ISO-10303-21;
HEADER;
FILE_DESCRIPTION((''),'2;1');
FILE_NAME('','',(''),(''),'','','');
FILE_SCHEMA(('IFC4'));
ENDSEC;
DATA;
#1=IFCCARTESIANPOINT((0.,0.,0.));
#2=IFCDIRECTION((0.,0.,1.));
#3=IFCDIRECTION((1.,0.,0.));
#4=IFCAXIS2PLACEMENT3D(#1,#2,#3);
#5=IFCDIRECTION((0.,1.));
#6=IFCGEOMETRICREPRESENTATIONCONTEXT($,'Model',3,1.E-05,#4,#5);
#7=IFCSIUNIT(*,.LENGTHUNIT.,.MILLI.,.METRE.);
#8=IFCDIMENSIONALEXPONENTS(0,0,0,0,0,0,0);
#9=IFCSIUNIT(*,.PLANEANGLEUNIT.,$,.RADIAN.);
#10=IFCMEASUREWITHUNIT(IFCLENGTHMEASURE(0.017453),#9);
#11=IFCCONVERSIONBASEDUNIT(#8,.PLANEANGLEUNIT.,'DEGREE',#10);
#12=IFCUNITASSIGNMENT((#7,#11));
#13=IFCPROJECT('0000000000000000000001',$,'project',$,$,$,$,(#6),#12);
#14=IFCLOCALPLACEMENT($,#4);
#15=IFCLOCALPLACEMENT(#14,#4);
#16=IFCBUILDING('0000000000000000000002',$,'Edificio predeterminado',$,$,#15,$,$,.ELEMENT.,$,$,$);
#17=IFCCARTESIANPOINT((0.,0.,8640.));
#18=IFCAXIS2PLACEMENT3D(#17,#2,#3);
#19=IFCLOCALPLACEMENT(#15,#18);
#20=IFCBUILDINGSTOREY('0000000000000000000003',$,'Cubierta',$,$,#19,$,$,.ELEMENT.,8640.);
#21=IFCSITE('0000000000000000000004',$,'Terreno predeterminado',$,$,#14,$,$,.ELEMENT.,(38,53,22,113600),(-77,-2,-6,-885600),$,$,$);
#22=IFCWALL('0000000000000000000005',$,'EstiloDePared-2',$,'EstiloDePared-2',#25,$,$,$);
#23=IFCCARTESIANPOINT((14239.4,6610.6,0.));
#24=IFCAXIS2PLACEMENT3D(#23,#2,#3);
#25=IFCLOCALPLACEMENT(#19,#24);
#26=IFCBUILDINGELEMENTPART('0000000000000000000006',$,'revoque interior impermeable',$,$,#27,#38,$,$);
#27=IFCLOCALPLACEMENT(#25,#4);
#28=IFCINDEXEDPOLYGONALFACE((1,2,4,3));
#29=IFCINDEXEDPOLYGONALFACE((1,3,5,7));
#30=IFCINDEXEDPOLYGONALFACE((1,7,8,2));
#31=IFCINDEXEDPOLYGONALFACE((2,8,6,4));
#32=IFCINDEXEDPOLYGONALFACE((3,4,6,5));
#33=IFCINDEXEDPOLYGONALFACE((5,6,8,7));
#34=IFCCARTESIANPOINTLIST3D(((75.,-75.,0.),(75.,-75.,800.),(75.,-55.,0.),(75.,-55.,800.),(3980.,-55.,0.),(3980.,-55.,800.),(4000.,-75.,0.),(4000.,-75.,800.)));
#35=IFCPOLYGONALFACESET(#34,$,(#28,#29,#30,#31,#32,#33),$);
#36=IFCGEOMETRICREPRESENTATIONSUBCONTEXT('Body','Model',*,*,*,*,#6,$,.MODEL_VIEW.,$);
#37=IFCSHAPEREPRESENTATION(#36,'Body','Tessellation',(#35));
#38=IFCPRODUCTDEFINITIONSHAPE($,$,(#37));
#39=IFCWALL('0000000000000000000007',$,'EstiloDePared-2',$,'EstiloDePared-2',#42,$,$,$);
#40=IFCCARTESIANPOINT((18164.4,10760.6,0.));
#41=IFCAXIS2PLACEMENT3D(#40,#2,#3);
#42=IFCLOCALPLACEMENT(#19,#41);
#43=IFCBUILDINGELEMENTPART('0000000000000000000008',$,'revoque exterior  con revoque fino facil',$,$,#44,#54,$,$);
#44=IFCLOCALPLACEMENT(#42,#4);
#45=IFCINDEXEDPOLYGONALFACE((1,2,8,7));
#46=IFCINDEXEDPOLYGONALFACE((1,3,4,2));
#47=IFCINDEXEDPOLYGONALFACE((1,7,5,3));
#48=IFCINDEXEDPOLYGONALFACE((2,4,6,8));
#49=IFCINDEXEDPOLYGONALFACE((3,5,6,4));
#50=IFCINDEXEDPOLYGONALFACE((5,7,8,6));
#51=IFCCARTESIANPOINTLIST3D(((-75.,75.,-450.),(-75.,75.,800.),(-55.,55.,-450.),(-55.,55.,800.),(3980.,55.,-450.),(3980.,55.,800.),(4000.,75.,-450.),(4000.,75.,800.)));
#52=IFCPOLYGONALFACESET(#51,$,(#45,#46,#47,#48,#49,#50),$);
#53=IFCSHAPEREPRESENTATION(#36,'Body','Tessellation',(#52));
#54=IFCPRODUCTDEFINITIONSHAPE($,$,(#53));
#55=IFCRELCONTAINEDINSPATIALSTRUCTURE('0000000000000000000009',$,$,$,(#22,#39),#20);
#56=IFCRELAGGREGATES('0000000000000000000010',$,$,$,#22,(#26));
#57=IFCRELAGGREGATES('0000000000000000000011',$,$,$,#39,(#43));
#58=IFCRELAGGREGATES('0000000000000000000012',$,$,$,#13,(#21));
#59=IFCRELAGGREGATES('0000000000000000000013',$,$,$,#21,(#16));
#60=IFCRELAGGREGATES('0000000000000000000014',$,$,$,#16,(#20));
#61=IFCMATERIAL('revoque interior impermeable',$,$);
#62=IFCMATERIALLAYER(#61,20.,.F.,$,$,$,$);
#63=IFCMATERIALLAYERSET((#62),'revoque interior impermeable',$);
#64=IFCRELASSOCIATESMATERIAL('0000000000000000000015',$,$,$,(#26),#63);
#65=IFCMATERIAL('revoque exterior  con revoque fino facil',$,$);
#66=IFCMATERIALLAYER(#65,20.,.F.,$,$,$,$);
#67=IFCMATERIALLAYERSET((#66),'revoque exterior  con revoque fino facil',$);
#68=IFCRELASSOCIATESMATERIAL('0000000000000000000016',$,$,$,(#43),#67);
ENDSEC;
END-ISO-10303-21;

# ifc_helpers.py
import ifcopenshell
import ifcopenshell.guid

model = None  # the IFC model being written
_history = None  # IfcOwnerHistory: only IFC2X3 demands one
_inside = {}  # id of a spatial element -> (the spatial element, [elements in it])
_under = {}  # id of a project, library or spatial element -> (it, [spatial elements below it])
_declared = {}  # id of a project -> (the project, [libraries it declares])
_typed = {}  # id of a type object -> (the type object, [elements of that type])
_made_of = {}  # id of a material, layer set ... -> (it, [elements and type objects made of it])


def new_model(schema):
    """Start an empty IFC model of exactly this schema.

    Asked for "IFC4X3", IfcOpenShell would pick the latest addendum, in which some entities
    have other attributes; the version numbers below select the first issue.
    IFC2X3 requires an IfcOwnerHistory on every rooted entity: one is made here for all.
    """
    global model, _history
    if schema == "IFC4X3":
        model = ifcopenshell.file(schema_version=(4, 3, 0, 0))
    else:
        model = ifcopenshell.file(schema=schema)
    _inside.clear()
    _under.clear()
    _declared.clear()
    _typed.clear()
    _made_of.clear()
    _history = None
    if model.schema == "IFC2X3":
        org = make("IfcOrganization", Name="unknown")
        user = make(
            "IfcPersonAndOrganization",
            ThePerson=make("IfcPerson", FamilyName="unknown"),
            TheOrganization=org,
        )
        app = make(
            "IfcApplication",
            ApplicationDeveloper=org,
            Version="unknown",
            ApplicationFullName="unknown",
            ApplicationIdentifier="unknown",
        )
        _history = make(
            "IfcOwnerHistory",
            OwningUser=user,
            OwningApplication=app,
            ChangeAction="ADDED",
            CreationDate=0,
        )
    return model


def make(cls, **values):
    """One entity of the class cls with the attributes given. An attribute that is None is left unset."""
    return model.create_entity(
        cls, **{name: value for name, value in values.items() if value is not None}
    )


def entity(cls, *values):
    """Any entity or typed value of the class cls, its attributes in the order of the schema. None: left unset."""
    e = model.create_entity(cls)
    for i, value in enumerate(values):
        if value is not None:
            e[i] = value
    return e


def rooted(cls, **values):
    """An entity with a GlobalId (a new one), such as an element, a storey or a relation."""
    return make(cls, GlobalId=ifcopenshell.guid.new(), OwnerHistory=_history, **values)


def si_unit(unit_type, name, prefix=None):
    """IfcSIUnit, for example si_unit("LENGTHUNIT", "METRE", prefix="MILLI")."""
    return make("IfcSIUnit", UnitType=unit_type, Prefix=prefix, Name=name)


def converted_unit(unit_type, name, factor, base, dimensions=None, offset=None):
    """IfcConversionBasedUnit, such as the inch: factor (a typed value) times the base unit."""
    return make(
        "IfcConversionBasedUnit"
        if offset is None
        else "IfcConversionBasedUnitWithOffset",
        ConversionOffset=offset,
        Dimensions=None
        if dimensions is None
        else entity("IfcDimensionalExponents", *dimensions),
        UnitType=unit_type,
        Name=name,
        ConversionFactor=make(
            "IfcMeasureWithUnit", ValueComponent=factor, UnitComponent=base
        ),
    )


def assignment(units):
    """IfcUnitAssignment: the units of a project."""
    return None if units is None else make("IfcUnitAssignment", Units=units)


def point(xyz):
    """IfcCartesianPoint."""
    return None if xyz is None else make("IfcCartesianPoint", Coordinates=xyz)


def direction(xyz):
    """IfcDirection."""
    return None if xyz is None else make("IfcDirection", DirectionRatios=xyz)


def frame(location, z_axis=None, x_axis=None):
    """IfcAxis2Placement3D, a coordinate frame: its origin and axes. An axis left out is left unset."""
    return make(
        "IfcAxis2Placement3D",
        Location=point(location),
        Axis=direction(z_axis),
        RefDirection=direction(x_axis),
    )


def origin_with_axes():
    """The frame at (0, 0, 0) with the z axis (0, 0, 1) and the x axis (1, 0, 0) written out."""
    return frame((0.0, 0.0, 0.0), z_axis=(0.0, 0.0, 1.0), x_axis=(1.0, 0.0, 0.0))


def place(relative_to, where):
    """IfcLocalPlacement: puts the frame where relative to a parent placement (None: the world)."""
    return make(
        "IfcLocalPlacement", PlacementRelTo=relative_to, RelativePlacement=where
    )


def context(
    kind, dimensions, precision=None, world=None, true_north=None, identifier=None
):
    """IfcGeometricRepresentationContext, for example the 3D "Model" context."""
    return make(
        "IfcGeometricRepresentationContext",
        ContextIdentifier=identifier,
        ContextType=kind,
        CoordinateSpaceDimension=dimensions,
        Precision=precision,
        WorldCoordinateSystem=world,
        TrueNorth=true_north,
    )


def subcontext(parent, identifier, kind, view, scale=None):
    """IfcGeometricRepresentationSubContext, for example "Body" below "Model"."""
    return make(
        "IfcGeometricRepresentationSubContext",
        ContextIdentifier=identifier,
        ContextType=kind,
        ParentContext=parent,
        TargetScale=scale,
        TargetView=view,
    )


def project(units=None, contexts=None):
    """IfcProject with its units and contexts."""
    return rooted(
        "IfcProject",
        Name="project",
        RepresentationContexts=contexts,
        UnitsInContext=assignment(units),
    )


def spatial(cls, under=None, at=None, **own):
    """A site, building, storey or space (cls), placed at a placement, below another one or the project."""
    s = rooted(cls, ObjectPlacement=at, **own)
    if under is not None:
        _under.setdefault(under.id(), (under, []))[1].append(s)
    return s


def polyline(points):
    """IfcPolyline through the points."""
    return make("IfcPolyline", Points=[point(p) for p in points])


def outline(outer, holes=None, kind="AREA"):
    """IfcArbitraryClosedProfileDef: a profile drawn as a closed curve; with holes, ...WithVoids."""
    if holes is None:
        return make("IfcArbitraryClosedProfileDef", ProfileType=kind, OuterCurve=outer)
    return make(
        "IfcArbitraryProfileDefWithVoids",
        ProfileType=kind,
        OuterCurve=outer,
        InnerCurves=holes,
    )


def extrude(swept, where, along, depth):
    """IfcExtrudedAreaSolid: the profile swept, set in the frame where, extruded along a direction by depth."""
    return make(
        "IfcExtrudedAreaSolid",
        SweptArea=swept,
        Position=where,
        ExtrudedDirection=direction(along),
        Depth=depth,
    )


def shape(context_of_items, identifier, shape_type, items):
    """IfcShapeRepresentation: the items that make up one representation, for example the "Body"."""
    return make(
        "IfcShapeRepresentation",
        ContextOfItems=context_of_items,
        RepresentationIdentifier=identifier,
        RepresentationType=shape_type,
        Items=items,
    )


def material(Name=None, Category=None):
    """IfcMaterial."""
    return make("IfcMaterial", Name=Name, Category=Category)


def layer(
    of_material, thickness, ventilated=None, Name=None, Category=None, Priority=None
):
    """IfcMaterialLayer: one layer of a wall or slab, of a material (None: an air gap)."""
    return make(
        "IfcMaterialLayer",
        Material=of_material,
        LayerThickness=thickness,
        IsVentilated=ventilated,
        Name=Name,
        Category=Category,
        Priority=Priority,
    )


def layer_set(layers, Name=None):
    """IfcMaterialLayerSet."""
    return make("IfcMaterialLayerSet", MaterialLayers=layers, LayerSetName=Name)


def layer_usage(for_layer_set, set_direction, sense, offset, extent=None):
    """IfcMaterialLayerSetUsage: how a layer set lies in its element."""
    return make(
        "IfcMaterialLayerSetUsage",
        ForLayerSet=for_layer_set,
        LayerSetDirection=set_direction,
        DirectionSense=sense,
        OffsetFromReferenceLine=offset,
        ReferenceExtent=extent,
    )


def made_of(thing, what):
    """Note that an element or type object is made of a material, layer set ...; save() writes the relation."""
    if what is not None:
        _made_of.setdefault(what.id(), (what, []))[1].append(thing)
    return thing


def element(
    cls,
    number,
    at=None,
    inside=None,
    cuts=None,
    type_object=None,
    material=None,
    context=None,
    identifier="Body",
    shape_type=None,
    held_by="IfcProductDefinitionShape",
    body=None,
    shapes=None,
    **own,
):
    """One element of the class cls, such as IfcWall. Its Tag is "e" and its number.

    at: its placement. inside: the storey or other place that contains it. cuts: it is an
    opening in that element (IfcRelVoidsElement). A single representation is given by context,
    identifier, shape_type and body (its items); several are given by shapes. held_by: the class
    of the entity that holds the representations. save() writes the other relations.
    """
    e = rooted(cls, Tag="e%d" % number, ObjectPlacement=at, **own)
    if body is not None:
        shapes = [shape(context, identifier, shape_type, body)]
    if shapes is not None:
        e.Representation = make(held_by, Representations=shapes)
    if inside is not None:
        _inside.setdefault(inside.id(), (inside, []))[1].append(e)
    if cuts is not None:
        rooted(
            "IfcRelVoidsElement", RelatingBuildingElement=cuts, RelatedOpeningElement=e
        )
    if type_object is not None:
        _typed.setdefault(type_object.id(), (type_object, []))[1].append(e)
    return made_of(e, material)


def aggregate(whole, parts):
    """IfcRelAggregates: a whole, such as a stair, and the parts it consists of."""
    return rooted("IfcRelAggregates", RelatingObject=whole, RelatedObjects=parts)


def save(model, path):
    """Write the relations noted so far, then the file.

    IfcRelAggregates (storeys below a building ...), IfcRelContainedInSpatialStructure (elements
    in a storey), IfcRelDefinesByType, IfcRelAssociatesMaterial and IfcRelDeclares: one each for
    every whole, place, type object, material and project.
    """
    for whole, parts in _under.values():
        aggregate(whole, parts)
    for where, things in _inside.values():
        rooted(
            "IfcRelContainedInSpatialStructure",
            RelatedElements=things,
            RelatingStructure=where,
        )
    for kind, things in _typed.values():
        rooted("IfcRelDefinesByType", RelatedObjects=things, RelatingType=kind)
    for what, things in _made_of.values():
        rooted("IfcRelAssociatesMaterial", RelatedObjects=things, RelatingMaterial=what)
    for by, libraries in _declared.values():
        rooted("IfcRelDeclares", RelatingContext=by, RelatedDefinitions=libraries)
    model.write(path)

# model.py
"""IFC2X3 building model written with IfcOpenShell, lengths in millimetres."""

from ifc_helpers import new_model, entity, si_unit, converted_unit, direction, frame, origin_with_axes, place, context, subcontext, project, spatial, polyline, outline, extrude, material, layer, layer_set, layer_usage, element, aggregate, save


model = new_model("IFC2X3")

# Units and contexts
model_context = context("Model", 3, precision=1e-05, world=origin_with_axes(), true_north=direction((0.0, 1.0)))
body_context = subcontext(model_context, "Body", "Model", "MODEL_VIEW")
ifc_project = project(units=[si_unit("LENGTHUNIT", "METRE", prefix="MILLI"), converted_unit("PLANEANGLEUNIT", "DEGREE", entity("IfcLengthMeasure", 0.017453), si_unit("PLANEANGLEUNIT", "RADIAN"), dimensions=[0, 0, 0, 0, 0, 0, 0])], contexts=[model_context])

# Site, building, storey
site_placement = place(None, origin_with_axes())
site = spatial("IfcSite", under=ifc_project, at=site_placement, Name="Terreno predeterminado", CompositionType="ELEMENT", RefLatitude=(38, 53, 22, 113600), RefLongitude=(-77, -2, -6, -885600))
building_placement = place(site_placement, origin_with_axes())
building = spatial("IfcBuilding", under=site, at=building_placement, Name="Edificio predeterminado", CompositionType="ELEMENT")
storey_placement = place(building_placement, frame((0.0, 0.0, 8640.0), z_axis=(0.0, 0.0, 1.0), x_axis=(1.0, 0.0, 0.0)))
storey = spatial("IfcBuildingStorey", under=building, at=storey_placement, Name="Cubierta", CompositionType="ELEMENT", Elevation=8640.0)

# Walls, building element parts
wall_1_placement = place(storey_placement, frame((14239.4, 6610.6, 0.0), z_axis=(0.0, 0.0, 1.0), x_axis=(1.0, 0.0, 0.0)))
wall_1 = element("IfcWall", 1, at=wall_1_placement, inside=storey, Name="EstiloDePared-2", ObjectType="EstiloDePared-2")
ifc_material_1 = material(Name="revoque interior impermeable")
ifc_layer_1 = layer(ifc_material_1, 20.0, ventilated=False)
ifc_layer_set_1 = layer_set([ifc_layer_1], Name="revoque interior impermeable")
ifc_layer_usage_1 = layer_usage(ifc_layer_set_1, "AXIS2", "NEGATIVE", 55.0)
building_element_part_1_placement = place(wall_1_placement, origin_with_axes())
building_element_part_1 = element("IfcBuildingElementPart", 2, at=building_element_part_1_placement, material=ifc_layer_usage_1, Name="revoque interior impermeable", context=body_context, shape_type="SweptSolid", body=[
    extrude(outline(polyline([(3980.0, -55.0), (4000.0, -75.0), (75.0, -75.0), (75.0, -55.0), (3980.0, -55.0)])), origin_with_axes(), (0.0, 0.0, 1.0), 800.0),
])
aggregate(wall_1, [building_element_part_1])
wall_2_placement = place(storey_placement, frame((18164.4, 10760.6, 0.0), z_axis=(0.0, 0.0, 1.0), x_axis=(1.0, 0.0, 0.0)))
wall_2 = element("IfcWall", 3, at=wall_2_placement, inside=storey, Name="EstiloDePared-2", ObjectType="EstiloDePared-2")
ifc_material_2 = material(Name="revoque exterior  con revoque fino facil")
ifc_layer_2 = layer(ifc_material_2, 20.0, ventilated=False)
ifc_layer_set_2 = layer_set([ifc_layer_2], Name="revoque exterior  con revoque fino facil")
ifc_layer_usage_2 = layer_usage(ifc_layer_set_2, "AXIS2", "NEGATIVE", -75.0)
building_element_part_2_placement = place(wall_2_placement, origin_with_axes())
building_element_part_2 = element("IfcBuildingElementPart", 4, at=building_element_part_2_placement, material=ifc_layer_usage_2, Name="revoque exterior  con revoque fino facil", context=body_context, shape_type="SweptSolid", body=[
    extrude(outline(polyline([(4000.0, 75.0), (3980.0, 55.0), (-55.0, 55.0), (-75.0, 75.0), (4000.0, 75.0)])), frame((0.0, 0.0, -450.0), z_axis=(0.0, 0.0, 1.0), x_axis=(1.0, 0.0, 0.0)), (0.0, 0.0, 1.0), 1250.0),
])
aggregate(wall_2, [building_element_part_2])

save(model, "model.ifc")
